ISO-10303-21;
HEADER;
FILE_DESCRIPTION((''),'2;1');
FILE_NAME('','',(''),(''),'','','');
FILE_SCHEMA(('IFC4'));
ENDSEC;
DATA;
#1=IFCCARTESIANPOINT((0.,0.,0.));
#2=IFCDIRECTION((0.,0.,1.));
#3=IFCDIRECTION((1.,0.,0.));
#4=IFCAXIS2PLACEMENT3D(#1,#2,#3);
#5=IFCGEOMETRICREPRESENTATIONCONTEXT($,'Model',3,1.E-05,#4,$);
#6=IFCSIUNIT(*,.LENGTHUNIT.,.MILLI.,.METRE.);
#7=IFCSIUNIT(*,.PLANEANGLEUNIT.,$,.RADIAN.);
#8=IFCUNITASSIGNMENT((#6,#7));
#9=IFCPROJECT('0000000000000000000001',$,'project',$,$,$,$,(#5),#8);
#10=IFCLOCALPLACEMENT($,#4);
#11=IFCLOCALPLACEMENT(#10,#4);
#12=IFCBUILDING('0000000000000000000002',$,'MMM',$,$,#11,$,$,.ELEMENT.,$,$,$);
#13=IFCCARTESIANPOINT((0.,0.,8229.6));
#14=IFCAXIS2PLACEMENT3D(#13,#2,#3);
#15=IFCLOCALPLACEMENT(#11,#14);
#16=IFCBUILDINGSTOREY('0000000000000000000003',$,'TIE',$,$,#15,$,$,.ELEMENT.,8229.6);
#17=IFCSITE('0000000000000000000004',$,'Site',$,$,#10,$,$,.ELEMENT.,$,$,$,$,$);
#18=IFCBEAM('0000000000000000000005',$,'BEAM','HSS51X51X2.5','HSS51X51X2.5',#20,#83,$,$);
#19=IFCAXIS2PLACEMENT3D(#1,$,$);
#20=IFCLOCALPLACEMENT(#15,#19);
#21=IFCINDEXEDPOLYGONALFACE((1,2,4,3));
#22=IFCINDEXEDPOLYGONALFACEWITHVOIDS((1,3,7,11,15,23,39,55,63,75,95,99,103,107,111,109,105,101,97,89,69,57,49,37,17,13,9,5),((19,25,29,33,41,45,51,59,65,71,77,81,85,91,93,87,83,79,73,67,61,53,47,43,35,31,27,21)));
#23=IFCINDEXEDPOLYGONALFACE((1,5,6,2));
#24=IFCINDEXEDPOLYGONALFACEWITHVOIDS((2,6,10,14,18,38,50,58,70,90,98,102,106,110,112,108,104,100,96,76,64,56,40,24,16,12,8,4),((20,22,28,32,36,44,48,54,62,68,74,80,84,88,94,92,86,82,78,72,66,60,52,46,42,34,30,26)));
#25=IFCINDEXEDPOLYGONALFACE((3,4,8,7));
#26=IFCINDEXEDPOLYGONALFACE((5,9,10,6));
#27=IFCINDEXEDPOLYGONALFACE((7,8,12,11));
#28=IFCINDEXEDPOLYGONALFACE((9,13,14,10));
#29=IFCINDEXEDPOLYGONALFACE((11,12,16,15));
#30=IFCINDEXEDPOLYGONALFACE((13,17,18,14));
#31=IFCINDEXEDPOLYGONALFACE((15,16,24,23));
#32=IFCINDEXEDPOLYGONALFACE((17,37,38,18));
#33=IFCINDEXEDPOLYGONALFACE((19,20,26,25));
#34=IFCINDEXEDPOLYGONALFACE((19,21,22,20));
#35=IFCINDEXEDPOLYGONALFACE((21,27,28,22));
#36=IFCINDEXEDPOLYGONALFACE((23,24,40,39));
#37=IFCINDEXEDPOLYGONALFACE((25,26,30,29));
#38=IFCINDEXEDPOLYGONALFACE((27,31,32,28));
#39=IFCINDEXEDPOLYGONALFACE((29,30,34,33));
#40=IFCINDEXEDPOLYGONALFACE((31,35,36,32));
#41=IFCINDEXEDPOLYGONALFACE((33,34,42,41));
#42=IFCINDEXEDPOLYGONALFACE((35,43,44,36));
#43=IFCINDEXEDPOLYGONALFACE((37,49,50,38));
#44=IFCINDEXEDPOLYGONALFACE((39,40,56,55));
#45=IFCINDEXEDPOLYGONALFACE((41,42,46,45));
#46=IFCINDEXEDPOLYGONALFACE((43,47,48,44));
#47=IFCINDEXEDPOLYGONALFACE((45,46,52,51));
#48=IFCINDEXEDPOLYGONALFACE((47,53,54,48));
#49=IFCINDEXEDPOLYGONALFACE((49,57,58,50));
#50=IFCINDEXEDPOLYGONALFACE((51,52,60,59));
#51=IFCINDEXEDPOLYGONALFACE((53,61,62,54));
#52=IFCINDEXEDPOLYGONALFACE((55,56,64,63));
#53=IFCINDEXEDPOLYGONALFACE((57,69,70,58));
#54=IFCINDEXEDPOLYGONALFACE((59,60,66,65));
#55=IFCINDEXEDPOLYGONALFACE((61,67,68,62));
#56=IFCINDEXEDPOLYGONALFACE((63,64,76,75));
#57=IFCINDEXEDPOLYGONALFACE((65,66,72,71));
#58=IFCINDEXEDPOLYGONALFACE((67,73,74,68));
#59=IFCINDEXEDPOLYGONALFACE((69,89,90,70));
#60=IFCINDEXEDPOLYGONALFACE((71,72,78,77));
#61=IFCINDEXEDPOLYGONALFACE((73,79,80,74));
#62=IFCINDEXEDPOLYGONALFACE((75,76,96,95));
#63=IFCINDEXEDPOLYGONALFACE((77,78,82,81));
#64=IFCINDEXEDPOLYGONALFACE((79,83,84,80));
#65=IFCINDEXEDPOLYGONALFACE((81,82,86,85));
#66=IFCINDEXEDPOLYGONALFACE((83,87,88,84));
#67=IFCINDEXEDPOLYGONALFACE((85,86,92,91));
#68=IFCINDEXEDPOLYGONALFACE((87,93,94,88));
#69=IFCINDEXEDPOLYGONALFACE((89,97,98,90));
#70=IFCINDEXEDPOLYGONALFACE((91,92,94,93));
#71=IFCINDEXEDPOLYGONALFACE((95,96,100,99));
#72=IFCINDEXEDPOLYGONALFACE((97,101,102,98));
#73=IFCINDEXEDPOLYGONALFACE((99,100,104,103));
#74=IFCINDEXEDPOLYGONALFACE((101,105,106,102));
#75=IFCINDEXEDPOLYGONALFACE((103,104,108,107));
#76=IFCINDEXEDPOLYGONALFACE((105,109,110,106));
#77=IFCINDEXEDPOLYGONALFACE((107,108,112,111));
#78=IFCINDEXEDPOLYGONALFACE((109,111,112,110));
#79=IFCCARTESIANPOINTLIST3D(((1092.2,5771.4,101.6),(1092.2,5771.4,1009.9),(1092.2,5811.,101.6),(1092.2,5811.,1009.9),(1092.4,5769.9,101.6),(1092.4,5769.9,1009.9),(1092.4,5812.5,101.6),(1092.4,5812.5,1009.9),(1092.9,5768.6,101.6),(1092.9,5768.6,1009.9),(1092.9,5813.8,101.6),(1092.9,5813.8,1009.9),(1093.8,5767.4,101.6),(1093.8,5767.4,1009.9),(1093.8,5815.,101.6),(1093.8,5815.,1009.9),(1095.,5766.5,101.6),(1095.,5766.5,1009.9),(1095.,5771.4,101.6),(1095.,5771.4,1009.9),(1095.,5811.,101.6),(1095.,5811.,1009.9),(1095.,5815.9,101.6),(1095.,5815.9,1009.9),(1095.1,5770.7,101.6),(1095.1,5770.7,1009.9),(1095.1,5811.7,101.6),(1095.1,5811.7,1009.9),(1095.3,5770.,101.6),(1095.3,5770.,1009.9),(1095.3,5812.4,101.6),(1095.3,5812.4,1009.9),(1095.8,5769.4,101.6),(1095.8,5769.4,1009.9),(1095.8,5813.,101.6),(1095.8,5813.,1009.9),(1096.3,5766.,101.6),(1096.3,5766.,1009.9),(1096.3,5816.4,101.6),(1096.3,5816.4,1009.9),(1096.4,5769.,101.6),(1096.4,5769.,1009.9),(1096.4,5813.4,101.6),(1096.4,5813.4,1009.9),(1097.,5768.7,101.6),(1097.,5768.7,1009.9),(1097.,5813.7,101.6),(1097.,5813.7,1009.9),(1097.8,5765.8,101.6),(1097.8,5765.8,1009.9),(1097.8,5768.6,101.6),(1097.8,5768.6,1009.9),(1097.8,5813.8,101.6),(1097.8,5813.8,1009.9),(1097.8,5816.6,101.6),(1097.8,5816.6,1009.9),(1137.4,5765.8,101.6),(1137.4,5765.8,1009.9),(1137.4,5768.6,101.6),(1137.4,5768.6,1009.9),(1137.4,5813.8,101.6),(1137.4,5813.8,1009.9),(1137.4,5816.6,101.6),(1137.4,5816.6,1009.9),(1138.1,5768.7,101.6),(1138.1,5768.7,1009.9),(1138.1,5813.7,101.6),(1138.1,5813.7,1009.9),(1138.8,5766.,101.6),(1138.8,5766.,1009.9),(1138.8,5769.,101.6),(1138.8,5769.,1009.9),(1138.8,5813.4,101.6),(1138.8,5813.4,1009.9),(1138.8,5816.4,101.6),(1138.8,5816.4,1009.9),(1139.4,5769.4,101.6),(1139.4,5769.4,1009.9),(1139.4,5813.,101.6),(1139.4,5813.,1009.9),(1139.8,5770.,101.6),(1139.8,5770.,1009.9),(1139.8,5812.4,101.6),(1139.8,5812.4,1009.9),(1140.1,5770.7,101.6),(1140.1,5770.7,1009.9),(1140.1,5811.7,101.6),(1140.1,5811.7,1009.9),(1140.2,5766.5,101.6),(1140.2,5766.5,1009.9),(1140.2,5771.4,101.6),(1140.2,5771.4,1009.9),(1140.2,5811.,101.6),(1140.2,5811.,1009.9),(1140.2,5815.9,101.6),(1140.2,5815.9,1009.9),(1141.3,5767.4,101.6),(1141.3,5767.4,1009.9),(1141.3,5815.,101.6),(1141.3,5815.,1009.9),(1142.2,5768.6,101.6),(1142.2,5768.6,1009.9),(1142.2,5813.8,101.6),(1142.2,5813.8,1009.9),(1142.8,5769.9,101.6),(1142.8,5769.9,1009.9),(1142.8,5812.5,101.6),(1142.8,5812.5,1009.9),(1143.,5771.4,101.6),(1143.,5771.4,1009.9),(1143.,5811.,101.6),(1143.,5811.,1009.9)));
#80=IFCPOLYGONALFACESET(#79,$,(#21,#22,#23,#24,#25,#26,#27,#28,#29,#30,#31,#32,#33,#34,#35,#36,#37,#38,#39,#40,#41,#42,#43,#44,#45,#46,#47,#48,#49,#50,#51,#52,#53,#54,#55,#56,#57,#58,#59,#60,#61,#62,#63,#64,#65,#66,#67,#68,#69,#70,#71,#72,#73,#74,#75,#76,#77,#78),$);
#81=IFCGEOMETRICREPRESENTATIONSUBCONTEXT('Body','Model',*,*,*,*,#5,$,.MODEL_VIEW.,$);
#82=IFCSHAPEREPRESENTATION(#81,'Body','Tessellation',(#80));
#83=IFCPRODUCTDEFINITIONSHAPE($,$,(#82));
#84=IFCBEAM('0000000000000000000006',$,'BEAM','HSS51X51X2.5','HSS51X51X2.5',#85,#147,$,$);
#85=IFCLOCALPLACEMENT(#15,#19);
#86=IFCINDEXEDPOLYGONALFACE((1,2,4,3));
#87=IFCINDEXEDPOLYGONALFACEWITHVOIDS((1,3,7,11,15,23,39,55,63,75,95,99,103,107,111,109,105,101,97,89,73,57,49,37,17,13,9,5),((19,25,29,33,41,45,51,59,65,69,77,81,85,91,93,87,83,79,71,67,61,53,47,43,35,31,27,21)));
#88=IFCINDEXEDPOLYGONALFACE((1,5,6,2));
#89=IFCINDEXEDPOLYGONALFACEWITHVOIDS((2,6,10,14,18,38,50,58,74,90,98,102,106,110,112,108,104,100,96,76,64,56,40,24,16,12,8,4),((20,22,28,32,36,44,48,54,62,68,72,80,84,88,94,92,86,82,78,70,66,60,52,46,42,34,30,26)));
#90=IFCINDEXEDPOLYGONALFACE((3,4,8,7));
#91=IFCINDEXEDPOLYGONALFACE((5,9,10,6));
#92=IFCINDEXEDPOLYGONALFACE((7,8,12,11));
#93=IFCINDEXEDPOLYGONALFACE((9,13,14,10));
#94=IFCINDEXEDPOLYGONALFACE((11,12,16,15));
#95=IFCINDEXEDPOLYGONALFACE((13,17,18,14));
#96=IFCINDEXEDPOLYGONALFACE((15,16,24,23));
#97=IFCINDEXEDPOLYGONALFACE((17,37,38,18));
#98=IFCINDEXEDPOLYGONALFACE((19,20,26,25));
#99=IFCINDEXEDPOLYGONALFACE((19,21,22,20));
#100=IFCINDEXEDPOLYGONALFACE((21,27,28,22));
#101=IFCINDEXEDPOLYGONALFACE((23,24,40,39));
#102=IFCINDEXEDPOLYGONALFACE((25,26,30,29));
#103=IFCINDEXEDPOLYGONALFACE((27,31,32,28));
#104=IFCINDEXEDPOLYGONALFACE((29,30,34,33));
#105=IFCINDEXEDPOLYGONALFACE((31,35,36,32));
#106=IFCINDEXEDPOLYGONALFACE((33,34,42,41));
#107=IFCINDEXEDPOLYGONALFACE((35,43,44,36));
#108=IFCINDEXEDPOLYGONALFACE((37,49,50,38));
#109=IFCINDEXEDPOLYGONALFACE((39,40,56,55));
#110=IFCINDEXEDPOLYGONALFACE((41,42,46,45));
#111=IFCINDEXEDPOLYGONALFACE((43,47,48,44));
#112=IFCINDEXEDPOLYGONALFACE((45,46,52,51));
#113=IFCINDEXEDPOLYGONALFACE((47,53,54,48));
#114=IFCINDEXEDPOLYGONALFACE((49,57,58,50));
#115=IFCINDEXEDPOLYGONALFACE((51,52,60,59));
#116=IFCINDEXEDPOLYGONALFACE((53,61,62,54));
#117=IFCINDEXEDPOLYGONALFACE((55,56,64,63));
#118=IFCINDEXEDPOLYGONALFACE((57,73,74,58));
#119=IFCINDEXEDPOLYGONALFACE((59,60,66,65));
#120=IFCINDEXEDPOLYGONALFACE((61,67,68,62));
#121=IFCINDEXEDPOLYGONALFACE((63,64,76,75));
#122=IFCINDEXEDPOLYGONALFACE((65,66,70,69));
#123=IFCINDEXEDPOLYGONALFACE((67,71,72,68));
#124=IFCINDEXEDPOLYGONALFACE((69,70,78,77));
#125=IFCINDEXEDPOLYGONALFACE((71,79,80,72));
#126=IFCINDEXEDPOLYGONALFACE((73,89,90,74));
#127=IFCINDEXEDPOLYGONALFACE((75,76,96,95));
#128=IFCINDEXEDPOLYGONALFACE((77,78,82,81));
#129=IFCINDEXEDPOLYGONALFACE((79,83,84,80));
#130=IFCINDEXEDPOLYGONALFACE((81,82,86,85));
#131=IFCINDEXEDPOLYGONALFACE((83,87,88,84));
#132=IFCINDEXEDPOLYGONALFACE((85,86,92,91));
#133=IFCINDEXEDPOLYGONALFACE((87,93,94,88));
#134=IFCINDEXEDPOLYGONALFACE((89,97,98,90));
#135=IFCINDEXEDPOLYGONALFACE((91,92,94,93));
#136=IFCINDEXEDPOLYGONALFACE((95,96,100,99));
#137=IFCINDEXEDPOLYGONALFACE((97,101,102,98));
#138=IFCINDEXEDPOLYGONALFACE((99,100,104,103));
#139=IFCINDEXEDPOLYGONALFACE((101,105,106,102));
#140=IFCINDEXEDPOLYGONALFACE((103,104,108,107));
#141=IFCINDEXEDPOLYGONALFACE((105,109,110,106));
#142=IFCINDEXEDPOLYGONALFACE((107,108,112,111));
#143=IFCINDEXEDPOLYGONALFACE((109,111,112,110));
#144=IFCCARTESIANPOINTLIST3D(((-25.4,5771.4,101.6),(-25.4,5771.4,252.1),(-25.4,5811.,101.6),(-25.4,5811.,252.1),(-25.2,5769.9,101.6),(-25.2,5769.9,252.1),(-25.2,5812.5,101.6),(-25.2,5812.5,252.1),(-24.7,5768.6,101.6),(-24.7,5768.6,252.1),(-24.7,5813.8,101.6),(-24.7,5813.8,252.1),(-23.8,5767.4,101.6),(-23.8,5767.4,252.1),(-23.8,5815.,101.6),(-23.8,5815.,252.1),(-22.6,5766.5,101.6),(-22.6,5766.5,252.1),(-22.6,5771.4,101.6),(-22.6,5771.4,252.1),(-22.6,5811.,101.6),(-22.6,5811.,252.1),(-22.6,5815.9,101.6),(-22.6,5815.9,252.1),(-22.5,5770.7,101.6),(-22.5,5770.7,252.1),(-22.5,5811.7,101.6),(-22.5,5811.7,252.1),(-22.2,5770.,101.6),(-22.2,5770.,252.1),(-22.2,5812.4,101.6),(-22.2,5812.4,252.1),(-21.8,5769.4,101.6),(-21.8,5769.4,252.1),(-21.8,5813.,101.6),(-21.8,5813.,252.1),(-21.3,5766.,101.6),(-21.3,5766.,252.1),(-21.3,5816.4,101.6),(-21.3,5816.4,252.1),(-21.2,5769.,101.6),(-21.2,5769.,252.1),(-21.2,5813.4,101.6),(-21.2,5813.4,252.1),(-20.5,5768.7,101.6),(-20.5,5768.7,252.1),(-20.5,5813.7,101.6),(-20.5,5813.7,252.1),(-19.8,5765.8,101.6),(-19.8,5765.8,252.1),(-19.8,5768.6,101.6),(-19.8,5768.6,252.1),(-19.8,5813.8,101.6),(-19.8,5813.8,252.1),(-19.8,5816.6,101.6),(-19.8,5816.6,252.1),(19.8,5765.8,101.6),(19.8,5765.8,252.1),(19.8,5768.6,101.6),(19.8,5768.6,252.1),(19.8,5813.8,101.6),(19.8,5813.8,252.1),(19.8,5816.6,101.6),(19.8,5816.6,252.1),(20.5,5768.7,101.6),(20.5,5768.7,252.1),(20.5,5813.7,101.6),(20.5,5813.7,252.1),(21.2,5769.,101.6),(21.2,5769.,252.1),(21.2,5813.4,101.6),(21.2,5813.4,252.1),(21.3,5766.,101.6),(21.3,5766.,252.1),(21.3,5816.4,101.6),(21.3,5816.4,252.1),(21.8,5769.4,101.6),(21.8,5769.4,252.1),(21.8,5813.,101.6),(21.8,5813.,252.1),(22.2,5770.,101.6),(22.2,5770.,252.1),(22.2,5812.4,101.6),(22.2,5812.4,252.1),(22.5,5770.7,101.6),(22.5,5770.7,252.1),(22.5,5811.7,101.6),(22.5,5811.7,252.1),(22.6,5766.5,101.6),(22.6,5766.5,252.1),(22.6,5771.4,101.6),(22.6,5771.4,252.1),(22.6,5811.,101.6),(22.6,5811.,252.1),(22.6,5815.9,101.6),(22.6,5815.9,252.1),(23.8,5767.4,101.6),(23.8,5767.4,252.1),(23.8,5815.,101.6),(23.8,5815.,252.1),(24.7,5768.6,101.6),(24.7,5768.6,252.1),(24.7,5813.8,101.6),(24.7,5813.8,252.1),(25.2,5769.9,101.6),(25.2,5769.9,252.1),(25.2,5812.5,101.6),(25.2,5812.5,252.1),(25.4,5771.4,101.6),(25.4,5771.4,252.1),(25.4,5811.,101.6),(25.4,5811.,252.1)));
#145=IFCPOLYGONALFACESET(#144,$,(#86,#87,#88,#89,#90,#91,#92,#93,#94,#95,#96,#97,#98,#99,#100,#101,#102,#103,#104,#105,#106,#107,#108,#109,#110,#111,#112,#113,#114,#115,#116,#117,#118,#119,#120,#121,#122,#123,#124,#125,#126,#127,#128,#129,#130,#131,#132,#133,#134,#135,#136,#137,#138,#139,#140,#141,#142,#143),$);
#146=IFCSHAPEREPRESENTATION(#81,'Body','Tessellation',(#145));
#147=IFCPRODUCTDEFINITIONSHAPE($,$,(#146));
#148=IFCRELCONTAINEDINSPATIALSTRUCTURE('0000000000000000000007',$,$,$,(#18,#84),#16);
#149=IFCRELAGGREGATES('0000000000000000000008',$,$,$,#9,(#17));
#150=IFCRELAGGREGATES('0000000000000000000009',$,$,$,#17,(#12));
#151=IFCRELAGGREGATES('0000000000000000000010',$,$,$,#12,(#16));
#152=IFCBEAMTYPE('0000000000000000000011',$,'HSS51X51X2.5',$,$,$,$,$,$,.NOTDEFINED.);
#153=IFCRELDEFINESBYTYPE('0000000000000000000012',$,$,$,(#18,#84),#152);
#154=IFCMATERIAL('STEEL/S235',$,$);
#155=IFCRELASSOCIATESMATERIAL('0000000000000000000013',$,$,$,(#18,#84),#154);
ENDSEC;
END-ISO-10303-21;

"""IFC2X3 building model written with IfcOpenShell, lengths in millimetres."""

from ifc_helpers import new_model, si_unit, frame, origin_with_axes, origin_2d_with_axis, place, context, subcontext, project, spatial, hollow_rectangle, extrude, material, type_object, element, save


model = new_model("IFC2X3")

# Units and contexts
model_context = context("Model", 3, precision=1e-05, world=origin_with_axes())
body_context = subcontext(model_context, "Body", "Model", "MODEL_VIEW")
ifc_project = project(units=[si_unit("LENGTHUNIT", "METRE", prefix="MILLI"), si_unit("PLANEANGLEUNIT", "RADIAN")], contexts=[model_context])

# Site, building, storey
site_placement = place(None, origin_with_axes())
site = spatial("IfcSite", under=ifc_project, at=site_placement, Name="Site", CompositionType="ELEMENT")
building_placement = place(site_placement, origin_with_axes())
building = spatial("IfcBuilding", under=site, at=building_placement, Name="MMM", CompositionType="ELEMENT")
storey_placement = place(building_placement, frame((0.0, 0.0, 8229.6), z_axis=(0.0, 0.0, 1.0), x_axis=(1.0, 0.0, 0.0)))
storey = spatial("IfcBuildingStorey", under=building, at=storey_placement, Name="TIE", CompositionType="ELEMENT", Elevation=8229.6)

# Beams
ifc_material = material(Name="STEEL/S235")
beam_type_1 = type_object("IfcBeamType", Name="HSS51X51X2.5", PredefinedType="NOTDEFINED")
beam_1_placement = place(storey_placement, frame((1117.6, 5791.2, 1009.9), z_axis=(1.0, 0.0, 0.0), x_axis=(0.0, 0.0, -1.0)))
element("IfcBeam", 1, at=beam_1_placement, inside=storey, type_object=beam_type_1, material=ifc_material, Name="BEAM", Description="HSS51X51X2.5", ObjectType="HSS51X51X2.5", context=body_context, shape_type="SweptSolid", body=[
    extrude(hollow_rectangle(XDim=50.8, YDim=50.8, WallThickness=2.8, InnerFilletRadius=2.8, OuterFilletRadius=5.6, at=origin_2d_with_axis()), frame((908.3, 0.0, 0.0), z_axis=(-1.0, 0.0, 0.0), x_axis=(0.0, -1.0, 0.0)), (0.0, 0.0, 1.0), 908.3),
])
beam_2_placement = place(storey_placement, frame((0.0, 5791.2, 252.1), z_axis=(1.0, 0.0, 0.0), x_axis=(0.0, 0.0, -1.0)))
element("IfcBeam", 2, at=beam_2_placement, inside=storey, type_object=beam_type_1, material=ifc_material, Name="BEAM", Description="HSS51X51X2.5", ObjectType="HSS51X51X2.5", context=body_context, shape_type="SweptSolid", body=[
    extrude(hollow_rectangle(XDim=50.8, YDim=50.8, WallThickness=2.8, InnerFilletRadius=2.8, OuterFilletRadius=5.6, at=origin_2d_with_axis()), frame((150.5, 0.0, 0.0), z_axis=(-1.0, 0.0, 0.0), x_axis=(0.0, -1.0, 0.0)), (0.0, 0.0, 1.0), 150.5),
])

save(model, "model.ifc")
